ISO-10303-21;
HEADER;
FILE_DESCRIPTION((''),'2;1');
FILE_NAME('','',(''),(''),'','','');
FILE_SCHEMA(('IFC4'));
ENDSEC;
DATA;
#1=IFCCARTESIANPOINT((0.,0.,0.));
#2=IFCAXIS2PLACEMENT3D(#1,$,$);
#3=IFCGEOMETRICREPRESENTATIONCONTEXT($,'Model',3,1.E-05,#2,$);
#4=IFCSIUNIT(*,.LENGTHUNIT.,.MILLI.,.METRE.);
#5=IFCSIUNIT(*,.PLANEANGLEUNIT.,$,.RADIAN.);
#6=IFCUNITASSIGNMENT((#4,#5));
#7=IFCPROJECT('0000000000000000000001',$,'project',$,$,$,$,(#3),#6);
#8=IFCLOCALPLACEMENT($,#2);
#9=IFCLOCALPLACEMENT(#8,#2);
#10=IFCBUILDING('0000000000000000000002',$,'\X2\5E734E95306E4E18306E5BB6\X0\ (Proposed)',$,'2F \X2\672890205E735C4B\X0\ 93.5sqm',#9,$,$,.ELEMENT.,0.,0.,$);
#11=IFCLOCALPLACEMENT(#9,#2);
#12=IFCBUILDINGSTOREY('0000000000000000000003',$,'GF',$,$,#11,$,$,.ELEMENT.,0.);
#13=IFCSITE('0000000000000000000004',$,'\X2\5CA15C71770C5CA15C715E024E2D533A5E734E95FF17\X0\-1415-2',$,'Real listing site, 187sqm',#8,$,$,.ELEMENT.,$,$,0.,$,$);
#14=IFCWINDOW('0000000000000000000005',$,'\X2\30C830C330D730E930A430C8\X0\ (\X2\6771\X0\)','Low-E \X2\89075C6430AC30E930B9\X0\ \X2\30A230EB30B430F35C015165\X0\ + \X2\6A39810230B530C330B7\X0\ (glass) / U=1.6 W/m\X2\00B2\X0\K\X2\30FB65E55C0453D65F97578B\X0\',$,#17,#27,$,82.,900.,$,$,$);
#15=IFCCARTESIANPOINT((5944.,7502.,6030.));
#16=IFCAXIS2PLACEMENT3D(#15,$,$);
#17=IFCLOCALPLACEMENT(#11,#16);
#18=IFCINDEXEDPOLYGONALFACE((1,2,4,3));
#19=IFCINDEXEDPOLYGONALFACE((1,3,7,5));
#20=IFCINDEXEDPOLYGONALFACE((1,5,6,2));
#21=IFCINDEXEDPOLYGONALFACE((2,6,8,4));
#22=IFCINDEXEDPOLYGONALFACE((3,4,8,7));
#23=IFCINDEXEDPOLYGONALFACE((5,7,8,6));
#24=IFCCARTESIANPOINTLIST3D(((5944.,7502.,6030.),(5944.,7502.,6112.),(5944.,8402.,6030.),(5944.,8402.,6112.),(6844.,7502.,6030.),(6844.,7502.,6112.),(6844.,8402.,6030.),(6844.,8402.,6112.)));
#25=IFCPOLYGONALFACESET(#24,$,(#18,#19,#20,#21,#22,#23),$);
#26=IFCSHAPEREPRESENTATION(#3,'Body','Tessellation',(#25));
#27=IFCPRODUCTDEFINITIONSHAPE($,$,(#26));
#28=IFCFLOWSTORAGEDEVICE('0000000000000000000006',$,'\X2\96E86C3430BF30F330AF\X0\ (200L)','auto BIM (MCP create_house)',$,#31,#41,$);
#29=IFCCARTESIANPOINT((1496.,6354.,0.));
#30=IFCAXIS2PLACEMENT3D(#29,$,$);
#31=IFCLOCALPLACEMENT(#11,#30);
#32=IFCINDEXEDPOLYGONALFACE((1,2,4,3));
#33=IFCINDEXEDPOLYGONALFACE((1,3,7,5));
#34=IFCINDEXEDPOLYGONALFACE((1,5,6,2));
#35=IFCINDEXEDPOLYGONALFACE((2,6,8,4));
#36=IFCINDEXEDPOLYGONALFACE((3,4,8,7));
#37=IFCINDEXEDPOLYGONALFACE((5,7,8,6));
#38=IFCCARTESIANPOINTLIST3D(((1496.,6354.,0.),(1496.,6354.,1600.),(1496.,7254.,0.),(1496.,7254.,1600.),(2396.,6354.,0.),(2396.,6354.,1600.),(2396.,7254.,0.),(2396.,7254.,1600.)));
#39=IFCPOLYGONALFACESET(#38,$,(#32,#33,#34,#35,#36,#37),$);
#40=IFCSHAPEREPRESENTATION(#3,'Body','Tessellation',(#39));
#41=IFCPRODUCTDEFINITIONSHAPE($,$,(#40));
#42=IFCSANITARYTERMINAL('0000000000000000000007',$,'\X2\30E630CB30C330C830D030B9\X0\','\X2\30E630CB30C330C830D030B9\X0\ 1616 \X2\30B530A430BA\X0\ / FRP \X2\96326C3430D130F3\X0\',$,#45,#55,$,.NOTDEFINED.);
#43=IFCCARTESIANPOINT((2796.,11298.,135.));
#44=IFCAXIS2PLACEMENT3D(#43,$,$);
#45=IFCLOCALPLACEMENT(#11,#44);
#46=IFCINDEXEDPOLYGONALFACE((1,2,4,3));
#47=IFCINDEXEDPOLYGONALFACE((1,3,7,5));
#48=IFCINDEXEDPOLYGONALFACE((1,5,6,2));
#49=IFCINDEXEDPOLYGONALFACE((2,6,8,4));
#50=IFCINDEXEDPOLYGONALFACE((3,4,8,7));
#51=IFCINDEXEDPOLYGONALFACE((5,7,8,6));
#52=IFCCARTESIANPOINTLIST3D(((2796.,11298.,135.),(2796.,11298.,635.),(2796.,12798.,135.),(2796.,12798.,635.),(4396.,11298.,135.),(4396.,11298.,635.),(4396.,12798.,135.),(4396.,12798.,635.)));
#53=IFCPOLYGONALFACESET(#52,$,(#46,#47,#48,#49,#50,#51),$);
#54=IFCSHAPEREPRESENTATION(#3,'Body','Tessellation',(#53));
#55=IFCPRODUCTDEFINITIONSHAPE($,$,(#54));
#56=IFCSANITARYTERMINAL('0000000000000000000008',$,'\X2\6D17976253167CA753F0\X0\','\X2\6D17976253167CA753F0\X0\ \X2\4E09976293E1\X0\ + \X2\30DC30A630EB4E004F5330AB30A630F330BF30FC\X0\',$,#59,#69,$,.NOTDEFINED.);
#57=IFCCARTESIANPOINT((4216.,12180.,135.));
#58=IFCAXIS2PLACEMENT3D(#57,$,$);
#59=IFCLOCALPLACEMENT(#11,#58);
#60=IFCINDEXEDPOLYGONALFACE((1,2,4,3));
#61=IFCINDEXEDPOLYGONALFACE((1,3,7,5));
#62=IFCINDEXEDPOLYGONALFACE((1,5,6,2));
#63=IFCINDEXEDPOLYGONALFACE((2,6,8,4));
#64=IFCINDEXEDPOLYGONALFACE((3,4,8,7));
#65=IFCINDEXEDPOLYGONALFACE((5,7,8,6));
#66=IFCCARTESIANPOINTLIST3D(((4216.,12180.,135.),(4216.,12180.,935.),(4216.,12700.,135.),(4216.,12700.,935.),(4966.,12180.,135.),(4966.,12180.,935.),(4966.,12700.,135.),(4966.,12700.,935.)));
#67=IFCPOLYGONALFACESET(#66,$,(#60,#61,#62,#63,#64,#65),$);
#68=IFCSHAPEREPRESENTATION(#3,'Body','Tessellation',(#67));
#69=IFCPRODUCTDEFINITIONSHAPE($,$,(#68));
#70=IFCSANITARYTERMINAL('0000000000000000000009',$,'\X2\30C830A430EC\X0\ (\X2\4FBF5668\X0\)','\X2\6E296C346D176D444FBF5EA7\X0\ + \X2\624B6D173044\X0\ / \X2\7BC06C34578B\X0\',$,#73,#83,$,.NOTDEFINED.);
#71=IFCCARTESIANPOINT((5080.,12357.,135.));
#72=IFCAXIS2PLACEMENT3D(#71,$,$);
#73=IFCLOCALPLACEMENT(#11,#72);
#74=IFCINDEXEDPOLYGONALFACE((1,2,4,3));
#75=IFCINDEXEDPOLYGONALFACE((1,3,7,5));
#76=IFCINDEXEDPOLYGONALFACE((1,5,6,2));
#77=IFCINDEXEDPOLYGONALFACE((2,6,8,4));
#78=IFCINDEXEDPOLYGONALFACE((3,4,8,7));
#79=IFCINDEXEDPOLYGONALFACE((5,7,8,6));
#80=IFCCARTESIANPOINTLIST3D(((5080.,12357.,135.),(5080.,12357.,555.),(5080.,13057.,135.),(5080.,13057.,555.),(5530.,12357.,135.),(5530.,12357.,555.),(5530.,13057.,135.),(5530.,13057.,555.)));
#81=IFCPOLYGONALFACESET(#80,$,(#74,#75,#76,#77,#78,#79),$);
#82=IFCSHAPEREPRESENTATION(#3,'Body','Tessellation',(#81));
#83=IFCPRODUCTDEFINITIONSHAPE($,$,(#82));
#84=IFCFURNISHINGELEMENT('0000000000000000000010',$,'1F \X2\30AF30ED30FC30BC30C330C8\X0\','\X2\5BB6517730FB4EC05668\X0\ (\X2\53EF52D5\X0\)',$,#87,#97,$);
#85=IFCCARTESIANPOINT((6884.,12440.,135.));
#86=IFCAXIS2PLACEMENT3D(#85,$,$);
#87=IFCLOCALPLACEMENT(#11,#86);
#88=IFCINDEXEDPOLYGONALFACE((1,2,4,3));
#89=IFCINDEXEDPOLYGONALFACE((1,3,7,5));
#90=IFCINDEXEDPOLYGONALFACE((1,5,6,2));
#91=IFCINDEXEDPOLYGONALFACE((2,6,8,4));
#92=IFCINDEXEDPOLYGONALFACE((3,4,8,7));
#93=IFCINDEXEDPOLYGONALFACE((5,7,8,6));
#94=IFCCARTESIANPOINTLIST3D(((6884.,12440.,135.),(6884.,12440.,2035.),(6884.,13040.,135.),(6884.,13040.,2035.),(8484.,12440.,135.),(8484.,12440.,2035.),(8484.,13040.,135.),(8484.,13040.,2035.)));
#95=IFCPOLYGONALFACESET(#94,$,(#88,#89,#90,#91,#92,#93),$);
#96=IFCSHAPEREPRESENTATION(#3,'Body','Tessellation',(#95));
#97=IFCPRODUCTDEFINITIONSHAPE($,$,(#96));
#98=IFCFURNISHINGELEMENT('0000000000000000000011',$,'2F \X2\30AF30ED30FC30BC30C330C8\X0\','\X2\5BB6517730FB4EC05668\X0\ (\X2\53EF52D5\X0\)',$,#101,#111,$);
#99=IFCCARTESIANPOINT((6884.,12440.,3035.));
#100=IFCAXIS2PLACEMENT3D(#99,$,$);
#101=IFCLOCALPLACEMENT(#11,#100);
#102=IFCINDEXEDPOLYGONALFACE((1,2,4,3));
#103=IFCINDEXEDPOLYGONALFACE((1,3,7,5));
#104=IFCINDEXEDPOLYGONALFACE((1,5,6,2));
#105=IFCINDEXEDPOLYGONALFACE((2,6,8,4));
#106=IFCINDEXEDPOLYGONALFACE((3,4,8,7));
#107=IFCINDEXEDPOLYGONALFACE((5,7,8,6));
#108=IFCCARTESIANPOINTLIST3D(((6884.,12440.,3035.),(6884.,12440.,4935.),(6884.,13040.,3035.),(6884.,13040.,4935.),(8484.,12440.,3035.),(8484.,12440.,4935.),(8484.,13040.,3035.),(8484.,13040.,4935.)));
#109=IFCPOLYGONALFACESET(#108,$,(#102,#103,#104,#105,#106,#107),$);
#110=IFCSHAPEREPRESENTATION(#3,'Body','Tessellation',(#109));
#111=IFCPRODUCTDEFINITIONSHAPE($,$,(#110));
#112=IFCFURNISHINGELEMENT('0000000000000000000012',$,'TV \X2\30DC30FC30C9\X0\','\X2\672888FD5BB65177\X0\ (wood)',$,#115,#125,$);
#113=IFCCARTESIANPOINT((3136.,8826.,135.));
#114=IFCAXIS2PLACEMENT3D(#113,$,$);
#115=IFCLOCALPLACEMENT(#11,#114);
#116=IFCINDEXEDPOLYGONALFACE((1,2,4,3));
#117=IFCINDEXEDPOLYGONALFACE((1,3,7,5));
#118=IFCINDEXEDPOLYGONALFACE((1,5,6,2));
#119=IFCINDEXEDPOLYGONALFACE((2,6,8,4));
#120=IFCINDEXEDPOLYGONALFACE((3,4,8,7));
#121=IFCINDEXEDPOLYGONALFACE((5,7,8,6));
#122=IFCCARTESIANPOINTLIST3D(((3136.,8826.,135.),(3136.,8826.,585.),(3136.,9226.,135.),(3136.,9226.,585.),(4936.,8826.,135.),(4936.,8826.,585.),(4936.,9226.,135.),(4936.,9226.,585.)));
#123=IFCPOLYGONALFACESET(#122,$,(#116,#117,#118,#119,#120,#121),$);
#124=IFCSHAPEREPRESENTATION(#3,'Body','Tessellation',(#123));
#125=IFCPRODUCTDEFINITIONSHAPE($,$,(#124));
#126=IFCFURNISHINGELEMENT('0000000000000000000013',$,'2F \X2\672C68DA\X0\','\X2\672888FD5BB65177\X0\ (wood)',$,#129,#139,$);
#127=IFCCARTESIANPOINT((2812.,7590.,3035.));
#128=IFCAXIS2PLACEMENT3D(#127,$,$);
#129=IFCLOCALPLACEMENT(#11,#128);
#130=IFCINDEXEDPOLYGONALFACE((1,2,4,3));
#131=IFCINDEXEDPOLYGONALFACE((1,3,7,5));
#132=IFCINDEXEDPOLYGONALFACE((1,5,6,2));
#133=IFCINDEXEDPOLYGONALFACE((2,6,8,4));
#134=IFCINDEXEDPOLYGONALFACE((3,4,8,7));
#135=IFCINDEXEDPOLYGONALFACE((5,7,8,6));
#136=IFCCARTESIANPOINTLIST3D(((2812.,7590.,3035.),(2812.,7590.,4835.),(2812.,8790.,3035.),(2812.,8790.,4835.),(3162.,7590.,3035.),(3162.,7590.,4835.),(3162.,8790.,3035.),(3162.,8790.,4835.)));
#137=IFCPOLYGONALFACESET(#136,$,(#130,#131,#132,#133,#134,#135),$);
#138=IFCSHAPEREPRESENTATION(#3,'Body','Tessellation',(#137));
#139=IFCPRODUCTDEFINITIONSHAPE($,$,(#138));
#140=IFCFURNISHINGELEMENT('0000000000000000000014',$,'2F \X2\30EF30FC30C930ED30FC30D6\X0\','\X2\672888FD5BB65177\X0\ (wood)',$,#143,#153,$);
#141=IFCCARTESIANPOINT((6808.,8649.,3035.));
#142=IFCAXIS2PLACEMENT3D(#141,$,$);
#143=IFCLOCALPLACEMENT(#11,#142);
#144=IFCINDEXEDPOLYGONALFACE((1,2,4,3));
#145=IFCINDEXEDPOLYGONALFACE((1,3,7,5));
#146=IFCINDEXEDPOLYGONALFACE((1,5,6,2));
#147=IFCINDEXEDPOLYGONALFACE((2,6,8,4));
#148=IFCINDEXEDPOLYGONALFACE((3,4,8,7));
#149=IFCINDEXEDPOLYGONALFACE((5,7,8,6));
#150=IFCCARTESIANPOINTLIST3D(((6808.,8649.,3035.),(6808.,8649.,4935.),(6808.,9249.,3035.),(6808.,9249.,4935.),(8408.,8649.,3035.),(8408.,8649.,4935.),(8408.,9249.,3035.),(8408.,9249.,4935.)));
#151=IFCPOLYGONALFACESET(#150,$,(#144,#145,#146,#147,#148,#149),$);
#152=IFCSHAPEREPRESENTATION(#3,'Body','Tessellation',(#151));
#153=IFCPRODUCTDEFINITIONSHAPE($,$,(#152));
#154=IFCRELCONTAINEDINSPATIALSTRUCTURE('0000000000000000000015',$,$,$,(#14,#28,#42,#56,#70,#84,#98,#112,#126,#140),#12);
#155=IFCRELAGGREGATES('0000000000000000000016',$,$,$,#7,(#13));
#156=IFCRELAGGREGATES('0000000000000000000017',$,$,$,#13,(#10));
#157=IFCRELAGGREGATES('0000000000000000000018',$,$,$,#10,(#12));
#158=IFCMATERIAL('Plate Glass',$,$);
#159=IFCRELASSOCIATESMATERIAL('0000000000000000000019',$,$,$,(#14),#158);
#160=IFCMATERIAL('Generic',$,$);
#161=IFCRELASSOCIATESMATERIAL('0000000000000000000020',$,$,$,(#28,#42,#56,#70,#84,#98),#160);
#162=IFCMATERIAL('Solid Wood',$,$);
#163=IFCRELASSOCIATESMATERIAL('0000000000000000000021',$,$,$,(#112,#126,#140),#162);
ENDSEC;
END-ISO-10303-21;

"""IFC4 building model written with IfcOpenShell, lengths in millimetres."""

from ifc_helpers import new_model, si_unit, frame, frame_2d, origin, place, context, project, spatial, rectangle, extrude, material, element, save


model = new_model("IFC4")

# Units and contexts
model_context = context("Model", 3, precision=1e-05, world=origin())
ifc_project = project(units=[si_unit("LENGTHUNIT", "METRE", prefix="MILLI"), si_unit("PLANEANGLEUNIT", "RADIAN")], contexts=[model_context])

# Site, building, storey
site_placement = place(None, origin())
site = spatial("IfcSite", under=ifc_project, at=site_placement, Name="岡山県岡山市中区平井７-1415-2", ObjectType="Real listing site, 187sqm", CompositionType="ELEMENT", RefElevation=0.0)
building_placement = place(site_placement, origin())
building = spatial("IfcBuilding", under=site, at=building_placement, Name="平井の丘の家 (Proposed)", ObjectType="2F 木造平屋 93.5sqm", CompositionType="ELEMENT", ElevationOfRefHeight=0.0, ElevationOfTerrain=0.0)
storey_placement = place(building_placement, origin())
storey = spatial("IfcBuildingStorey", under=building, at=storey_placement, Name="GF", CompositionType="ELEMENT", Elevation=0.0)

# Shared definitions
ifc_material_1 = material(Name="Solid Wood")
ifc_material_2 = material(Name="Plate Glass")

# Window
window_1_placement = place(storey_placement, frame((5944.0, 7502.0, 6030.0)))
element("IfcWindow", 1, at=window_1_placement, inside=storey, material=ifc_material_2, Name="トップライト (東)", Description="Low-E 複層ガラス アルゴン封入 + 樹脂サッシ (glass) / U=1.6 W/m²K・日射取得型", OverallHeight=82.0, OverallWidth=900.0, context=model_context, shape_type="SweptSolid", body=[
    extrude(rectangle(XDim=900.0, YDim=900.0, at=frame_2d((450.0, 450.0))), frame((5944.0, 7502.0, 6030.0)), (0.0, 0.0, 1.0), 82.0),
])

# Flow storage device
ifc_material_3 = material(Name="Generic")
flow_storage_device_placement = place(storey_placement, frame((1496.0, 6354.0, 0.0)))
element("IfcFlowStorageDevice", 2, at=flow_storage_device_placement, inside=storey, material=ifc_material_3, Name="雨水タンク (200L)", Description="auto BIM (MCP create_house)", context=model_context, shape_type="SweptSolid", body=[
    extrude(rectangle(XDim=900.0, YDim=900.0, at=frame_2d((450.0, 450.0))), frame((1496.0, 6354.0, 0.0)), (0.0, 0.0, 1.0), 1600.0),
])

# Sanitary terminals
sanitary_terminal_1_placement = place(storey_placement, frame((2796.0, 11298.0, 135.0)))
element("IfcSanitaryTerminal", 3, at=sanitary_terminal_1_placement, inside=storey, material=ifc_material_3, Name="ユニットバス", Description="ユニットバス 1616 サイズ / FRP 防水パン", PredefinedType="NOTDEFINED", context=model_context, shape_type="SweptSolid", body=[
    extrude(rectangle(XDim=1600.0, YDim=1500.0, at=frame_2d((800.0, 750.0))), frame((2796.0, 11298.0, 135.0)), (0.0, 0.0, 1.0), 500.0),
])
sanitary_terminal_2_placement = place(storey_placement, frame((4216.0, 12180.0, 135.0)))
element("IfcSanitaryTerminal", 4, at=sanitary_terminal_2_placement, inside=storey, material=ifc_material_3, Name="洗面化粧台", Description="洗面化粧台 三面鏡 + ボウル一体カウンター", PredefinedType="NOTDEFINED", context=model_context, shape_type="SweptSolid", body=[
    extrude(rectangle(XDim=750.0, YDim=520.0, at=frame_2d((375.0, 260.0))), frame((4216.0, 12180.0, 135.0)), (0.0, 0.0, 1.0), 800.0),
])
sanitary_terminal_3_placement = place(storey_placement, frame((5080.0, 12357.0, 135.0)))
element("IfcSanitaryTerminal", 5, at=sanitary_terminal_3_placement, inside=storey, material=ifc_material_3, Name="トイレ (便器)", Description="温水洗浄便座 + 手洗い / 節水型", PredefinedType="NOTDEFINED", context=model_context, shape_type="SweptSolid", body=[
    extrude(rectangle(XDim=450.0, YDim=700.0, at=frame_2d((225.0, 350.0))), frame((5080.0, 12357.0, 135.0)), (0.0, 0.0, 1.0), 420.0),
])

# Furnishing elements
furnishing_1_placement = place(storey_placement, frame((6884.0, 12440.0, 135.0)))
element("IfcFurnishingElement", 6, at=furnishing_1_placement, inside=storey, material=ifc_material_3, Name="1F クローゼット", Description="家具・什器 (可動)", context=model_context, shape_type="SweptSolid", body=[
    extrude(rectangle(XDim=1600.0, YDim=600.0, at=frame_2d((800.0, 300.0))), frame((6884.0, 12440.0, 135.0)), (0.0, 0.0, 1.0), 1900.0),
])
furnishing_2_placement = place(storey_placement, frame((6884.0, 12440.0, 3035.0)))
element("IfcFurnishingElement", 7, at=furnishing_2_placement, inside=storey, material=ifc_material_3, Name="2F クローゼット", Description="家具・什器 (可動)", context=model_context, shape_type="SweptSolid", body=[
    extrude(rectangle(XDim=1600.0, YDim=600.0, at=frame_2d((800.0, 300.0))), frame((6884.0, 12440.0, 3035.0)), (0.0, 0.0, 1.0), 1900.0),
])
furnishing_3_placement = place(storey_placement, frame((3136.0, 8826.0, 135.0)))
element("IfcFurnishingElement", 8, at=furnishing_3_placement, inside=storey, material=ifc_material_1, Name="TV ボード", Description="木製家具 (wood)", context=model_context, shape_type="SweptSolid", body=[
    extrude(rectangle(XDim=1800.0, YDim=400.0, at=frame_2d((900.0, 200.0))), frame((3136.0, 8826.0, 135.0)), (0.0, 0.0, 1.0), 450.0),
])
furnishing_4_placement = place(storey_placement, frame((2812.0, 7590.0, 3035.0)))
element("IfcFurnishingElement", 9, at=furnishing_4_placement, inside=storey, material=ifc_material_1, Name="2F 本棚", Description="木製家具 (wood)", context=model_context, shape_type="SweptSolid", body=[
    extrude(rectangle(XDim=350.0, YDim=1200.0, at=frame_2d((175.0, 600.0))), frame((2812.0, 7590.0, 3035.0)), (0.0, 0.0, 1.0), 1800.0),
])
furnishing_5_placement = place(storey_placement, frame((6808.0, 8649.0, 3035.0)))
element("IfcFurnishingElement", 10, at=furnishing_5_placement, inside=storey, material=ifc_material_1, Name="2F ワードローブ", Description="木製家具 (wood)", context=model_context, shape_type="SweptSolid", body=[
    extrude(rectangle(XDim=1600.0, YDim=600.0, at=frame_2d((800.0, 300.0))), frame((6808.0, 8649.0, 3035.0)), (0.0, 0.0, 1.0), 1900.0),
])

save(model, "model.ifc")
